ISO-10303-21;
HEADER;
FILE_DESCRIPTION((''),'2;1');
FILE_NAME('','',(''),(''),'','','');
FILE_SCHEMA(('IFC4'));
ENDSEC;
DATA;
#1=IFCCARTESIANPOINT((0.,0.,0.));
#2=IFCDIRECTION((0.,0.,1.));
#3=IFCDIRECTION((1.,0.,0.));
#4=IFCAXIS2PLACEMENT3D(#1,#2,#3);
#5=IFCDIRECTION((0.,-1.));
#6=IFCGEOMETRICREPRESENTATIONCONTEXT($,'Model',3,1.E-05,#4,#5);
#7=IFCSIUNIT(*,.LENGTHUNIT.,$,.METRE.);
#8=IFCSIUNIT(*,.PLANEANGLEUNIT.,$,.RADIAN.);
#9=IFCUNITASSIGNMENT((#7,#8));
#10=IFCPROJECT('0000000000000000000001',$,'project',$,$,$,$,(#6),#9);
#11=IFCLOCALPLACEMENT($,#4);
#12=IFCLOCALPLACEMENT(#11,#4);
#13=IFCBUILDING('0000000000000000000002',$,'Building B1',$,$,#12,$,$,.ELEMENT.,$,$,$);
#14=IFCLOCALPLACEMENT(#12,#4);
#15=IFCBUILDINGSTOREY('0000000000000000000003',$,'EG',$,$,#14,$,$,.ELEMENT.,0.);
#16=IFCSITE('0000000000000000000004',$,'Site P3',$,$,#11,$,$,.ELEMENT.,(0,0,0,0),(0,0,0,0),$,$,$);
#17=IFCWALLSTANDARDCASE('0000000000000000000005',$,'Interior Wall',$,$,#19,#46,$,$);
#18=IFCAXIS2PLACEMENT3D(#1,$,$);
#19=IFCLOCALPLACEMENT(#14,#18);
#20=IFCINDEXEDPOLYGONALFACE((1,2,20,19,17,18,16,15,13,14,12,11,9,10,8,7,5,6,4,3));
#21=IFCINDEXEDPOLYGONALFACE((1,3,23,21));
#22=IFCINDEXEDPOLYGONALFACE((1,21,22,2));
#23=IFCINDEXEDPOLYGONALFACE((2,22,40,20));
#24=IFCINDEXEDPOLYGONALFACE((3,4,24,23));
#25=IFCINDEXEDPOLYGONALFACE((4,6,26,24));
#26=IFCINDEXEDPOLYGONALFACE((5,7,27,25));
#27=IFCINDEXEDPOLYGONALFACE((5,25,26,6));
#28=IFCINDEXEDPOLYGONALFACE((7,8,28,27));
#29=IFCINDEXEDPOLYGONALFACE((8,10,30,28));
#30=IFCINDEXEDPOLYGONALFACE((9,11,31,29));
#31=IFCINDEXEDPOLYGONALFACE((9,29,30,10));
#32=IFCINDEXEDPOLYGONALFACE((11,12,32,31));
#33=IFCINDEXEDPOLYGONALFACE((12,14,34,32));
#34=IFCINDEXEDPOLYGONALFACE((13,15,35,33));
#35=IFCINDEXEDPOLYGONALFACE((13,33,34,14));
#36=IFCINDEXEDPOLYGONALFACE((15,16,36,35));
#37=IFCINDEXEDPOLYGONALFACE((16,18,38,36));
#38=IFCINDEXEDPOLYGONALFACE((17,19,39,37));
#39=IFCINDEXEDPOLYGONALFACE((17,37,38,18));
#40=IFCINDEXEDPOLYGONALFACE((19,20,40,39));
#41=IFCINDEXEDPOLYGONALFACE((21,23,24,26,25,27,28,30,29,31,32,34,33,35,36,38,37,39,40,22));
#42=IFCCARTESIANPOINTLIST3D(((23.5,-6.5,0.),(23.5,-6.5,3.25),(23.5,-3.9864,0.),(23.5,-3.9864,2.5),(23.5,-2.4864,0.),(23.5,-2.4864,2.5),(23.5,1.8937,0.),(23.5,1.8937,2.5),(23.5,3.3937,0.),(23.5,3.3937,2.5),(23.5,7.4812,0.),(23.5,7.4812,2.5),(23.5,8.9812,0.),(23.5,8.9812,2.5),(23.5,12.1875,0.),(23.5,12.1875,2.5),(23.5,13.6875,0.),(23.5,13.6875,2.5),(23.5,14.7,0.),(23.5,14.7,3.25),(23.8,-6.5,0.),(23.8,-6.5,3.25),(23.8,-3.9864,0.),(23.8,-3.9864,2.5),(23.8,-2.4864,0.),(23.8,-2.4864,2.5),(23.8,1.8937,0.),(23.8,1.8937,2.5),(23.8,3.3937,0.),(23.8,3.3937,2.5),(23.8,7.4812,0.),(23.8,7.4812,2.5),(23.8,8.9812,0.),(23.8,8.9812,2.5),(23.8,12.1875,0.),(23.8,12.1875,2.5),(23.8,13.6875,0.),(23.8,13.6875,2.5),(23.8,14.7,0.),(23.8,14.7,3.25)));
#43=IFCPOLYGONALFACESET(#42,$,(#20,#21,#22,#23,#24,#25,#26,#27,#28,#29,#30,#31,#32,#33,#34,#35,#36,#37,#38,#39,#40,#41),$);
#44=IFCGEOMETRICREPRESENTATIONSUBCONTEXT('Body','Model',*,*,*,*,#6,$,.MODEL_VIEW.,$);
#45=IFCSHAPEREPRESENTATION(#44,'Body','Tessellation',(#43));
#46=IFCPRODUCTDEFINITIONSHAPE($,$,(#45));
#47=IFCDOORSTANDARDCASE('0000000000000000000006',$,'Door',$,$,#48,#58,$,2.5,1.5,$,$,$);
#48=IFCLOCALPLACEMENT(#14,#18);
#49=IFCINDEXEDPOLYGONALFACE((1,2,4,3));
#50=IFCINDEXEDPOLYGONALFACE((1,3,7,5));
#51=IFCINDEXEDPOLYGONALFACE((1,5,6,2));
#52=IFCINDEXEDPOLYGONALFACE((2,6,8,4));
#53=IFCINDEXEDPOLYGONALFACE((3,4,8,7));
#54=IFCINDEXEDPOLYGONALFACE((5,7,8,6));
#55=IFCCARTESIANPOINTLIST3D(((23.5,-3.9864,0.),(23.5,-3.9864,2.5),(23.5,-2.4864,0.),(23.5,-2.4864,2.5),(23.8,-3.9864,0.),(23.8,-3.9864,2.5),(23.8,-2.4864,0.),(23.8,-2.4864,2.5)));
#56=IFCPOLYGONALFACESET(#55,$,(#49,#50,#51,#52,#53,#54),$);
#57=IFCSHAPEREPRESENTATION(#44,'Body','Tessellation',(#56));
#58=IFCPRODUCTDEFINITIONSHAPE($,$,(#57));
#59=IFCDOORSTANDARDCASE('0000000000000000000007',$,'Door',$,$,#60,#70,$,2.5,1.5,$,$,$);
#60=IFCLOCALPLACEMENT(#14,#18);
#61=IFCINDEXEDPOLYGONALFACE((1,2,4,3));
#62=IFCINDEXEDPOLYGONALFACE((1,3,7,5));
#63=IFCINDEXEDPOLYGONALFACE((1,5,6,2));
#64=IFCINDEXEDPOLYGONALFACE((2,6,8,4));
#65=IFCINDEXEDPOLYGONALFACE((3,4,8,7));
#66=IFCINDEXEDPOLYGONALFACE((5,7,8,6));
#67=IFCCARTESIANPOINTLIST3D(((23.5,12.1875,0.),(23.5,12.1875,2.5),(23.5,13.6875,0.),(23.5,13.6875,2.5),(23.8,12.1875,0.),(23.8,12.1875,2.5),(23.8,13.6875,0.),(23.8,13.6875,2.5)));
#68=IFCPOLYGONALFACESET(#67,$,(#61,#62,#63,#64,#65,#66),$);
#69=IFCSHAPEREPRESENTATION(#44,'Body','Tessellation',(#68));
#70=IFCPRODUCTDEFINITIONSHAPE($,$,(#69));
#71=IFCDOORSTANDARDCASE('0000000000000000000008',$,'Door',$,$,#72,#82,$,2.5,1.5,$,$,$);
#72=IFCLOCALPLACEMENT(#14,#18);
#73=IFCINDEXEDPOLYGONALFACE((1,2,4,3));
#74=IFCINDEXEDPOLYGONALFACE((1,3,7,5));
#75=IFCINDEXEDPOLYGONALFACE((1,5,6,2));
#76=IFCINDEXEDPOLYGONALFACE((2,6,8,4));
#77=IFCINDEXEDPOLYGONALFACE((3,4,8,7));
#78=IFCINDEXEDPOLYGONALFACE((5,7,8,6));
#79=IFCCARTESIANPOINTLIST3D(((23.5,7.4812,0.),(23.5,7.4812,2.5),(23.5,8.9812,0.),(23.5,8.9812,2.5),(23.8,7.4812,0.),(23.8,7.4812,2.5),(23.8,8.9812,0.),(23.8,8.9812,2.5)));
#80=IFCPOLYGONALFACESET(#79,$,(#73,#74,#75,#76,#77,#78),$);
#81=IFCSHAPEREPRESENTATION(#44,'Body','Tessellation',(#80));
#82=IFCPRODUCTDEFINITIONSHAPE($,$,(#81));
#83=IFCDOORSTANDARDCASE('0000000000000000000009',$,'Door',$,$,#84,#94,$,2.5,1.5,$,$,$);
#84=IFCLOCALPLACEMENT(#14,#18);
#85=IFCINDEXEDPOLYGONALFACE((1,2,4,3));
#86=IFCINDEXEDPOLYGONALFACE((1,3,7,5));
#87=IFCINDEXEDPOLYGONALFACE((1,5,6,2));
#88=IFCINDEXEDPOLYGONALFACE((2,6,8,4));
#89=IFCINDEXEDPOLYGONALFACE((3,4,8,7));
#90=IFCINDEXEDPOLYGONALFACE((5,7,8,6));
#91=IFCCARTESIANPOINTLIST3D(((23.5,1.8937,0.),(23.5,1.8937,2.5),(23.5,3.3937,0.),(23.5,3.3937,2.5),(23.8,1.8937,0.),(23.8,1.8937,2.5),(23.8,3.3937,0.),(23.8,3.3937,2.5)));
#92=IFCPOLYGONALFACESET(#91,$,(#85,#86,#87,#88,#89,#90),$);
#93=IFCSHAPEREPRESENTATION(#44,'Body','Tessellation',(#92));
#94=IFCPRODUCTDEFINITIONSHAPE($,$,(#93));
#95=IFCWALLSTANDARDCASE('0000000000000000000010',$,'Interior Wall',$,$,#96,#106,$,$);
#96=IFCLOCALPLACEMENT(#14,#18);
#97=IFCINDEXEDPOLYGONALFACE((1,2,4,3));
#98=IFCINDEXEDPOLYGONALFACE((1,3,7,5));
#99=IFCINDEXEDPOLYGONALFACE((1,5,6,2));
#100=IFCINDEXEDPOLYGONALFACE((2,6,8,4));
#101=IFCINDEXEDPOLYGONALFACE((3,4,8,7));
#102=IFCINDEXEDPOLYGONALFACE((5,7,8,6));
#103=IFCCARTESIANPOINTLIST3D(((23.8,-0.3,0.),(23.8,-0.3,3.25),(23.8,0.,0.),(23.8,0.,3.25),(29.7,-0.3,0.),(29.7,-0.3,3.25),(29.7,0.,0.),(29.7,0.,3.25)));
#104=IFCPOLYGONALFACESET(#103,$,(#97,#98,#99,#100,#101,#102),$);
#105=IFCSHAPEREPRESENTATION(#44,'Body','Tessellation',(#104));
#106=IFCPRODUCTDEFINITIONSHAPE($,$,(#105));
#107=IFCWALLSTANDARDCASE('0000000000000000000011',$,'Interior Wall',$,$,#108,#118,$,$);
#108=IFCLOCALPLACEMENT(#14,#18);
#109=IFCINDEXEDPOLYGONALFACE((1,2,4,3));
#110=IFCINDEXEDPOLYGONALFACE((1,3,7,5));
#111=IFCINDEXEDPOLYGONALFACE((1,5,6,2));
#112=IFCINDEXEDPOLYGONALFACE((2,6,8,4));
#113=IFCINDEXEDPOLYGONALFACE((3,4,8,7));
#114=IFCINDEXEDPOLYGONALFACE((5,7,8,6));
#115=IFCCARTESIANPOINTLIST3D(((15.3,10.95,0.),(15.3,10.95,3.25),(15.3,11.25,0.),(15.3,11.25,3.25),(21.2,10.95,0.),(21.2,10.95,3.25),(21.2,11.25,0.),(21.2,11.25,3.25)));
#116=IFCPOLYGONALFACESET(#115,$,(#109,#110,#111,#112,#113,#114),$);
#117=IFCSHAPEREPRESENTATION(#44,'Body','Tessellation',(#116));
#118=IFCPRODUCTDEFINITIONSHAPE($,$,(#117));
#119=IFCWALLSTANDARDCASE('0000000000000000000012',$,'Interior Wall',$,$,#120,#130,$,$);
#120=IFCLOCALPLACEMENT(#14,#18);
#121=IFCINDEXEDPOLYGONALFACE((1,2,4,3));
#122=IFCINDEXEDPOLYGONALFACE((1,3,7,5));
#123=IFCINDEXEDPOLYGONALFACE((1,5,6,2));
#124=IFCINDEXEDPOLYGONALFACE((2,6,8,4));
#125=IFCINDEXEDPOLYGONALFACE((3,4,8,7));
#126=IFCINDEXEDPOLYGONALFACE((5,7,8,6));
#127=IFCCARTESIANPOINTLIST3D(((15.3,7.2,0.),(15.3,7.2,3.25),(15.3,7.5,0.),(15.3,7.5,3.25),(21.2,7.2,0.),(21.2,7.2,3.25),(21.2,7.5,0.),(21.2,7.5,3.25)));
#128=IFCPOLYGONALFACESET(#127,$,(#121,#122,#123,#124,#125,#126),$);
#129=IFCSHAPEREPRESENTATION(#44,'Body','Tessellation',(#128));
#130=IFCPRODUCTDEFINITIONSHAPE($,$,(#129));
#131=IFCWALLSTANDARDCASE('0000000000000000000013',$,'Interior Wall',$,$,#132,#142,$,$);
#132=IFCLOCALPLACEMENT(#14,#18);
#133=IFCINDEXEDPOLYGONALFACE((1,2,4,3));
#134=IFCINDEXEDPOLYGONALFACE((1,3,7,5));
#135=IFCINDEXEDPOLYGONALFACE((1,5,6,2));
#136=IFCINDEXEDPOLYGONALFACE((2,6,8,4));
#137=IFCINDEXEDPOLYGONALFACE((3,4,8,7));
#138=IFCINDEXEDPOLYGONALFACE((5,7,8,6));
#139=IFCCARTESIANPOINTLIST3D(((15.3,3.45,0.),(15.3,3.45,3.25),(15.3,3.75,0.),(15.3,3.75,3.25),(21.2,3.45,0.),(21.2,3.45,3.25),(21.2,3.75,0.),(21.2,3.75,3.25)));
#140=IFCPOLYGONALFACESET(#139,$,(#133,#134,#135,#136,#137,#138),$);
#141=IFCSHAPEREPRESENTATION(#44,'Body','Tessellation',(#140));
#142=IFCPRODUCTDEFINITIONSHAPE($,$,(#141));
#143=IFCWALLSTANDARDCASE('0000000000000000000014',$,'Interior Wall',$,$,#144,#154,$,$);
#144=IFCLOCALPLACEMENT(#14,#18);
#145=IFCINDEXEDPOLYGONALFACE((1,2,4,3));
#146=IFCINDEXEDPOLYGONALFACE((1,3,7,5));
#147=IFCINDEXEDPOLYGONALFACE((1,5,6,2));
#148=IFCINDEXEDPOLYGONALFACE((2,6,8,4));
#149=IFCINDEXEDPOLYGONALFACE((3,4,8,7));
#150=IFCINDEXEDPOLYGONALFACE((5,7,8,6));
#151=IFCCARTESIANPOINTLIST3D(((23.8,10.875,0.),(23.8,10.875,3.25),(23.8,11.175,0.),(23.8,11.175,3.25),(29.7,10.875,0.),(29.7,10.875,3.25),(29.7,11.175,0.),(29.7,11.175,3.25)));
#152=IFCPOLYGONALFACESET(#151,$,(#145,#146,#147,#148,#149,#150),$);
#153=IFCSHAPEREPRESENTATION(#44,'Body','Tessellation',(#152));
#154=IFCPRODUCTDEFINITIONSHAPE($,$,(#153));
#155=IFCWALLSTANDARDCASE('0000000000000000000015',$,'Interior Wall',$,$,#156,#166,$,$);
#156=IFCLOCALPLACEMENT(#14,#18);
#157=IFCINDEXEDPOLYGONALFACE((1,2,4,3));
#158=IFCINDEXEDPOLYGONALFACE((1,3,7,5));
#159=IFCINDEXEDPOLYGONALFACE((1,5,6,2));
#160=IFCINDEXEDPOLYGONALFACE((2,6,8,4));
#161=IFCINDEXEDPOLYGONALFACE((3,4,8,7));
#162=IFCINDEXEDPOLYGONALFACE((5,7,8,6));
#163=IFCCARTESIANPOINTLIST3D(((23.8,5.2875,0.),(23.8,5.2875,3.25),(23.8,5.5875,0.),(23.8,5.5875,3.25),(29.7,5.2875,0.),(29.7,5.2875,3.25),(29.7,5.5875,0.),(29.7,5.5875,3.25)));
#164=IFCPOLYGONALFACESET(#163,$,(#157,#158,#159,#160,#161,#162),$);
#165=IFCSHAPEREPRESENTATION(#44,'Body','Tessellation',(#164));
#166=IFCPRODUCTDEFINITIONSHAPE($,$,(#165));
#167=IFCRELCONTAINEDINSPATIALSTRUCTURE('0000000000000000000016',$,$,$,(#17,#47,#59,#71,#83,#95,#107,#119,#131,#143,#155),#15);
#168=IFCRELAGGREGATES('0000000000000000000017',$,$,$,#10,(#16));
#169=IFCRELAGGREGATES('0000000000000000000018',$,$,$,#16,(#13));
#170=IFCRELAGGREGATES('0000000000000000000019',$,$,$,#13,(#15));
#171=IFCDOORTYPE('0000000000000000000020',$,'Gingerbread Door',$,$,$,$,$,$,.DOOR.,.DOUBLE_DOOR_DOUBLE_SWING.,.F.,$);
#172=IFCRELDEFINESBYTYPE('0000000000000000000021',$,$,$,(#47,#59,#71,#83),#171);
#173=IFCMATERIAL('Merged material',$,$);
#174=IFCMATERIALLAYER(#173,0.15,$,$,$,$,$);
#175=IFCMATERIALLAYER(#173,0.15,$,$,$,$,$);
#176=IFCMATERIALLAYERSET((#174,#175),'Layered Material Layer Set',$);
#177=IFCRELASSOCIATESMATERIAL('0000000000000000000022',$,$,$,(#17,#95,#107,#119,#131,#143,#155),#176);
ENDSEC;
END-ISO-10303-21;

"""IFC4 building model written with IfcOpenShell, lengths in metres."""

from ifc_helpers import new_model, si_unit, direction, frame, origin_with_axes, place, context, subcontext, project, spatial, polyline, outline, extrude, source, transform, mapped, material, layer, layer_set, layer_usage, type_object, element, fill, save


model = new_model("IFC4")

# Units and contexts
model_context = context("Model", 3, precision=1e-05, world=origin_with_axes(), true_north=direction((0.0, -1.0)))
body_context = subcontext(model_context, "Body", "Model", "MODEL_VIEW")
ifc_project = project(units=[si_unit("LENGTHUNIT", "METRE"), si_unit("PLANEANGLEUNIT", "RADIAN")], contexts=[model_context])

# Site, building, storey
site_placement = place(None, origin_with_axes())
site = spatial("IfcSite", under=ifc_project, at=site_placement, Name="Site P3", CompositionType="ELEMENT", RefLatitude=(0, 0, 0, 0), RefLongitude=(0, 0, 0, 0))
building_placement = place(site_placement, origin_with_axes())
building = spatial("IfcBuilding", under=site, at=building_placement, Name="Building B1", CompositionType="ELEMENT")
storey_placement = place(building_placement, origin_with_axes())
storey = spatial("IfcBuildingStorey", under=building, at=storey_placement, Name="EG", CompositionType="ELEMENT", Elevation=0.0)

# Shared definitions
ifc_material = material(Name="Merged material")

# Wall, openings, doors
ifc_layer_1 = layer(ifc_material, 0.15)
ifc_layer_2 = layer(ifc_material, 0.15)
ifc_layer_set_1 = layer_set([ifc_layer_1, ifc_layer_2], Name="Layered Material Layer Set")
ifc_layer_usage_1 = layer_usage(ifc_layer_set_1, "AXIS2", "POSITIVE", -0.15)
door_type = type_object("IfcDoorType", Name="Gingerbread Door", OperationType="DOUBLE_DOOR_DOUBLE_SWING", ParameterTakesPrecedence=False, PredefinedType="DOOR")
shared_shape_1 = source(origin_with_axes(), body_context, "Body", "SweptSolid", [
    extrude(outline(polyline([(0.0, 0.0), (0.0, 1.5), (2.5, 1.5), (2.5, 0.0), (0.0, 0.0)])), frame((0.0, -0.15, 0.0), z_axis=(0.0, 1.0, 0.0), x_axis=(0.0, 0.0, 1.0)), (0.0, 0.0, 1.0), 0.3),
])
wall_1_placement = place(storey_placement, frame((23.65, 14.7, 0.0), z_axis=(0.0, 0.0, 1.0), x_axis=(0.0, -1.0, 0.0)))
wall_1 = element("IfcWallStandardCase", 1, at=wall_1_placement, inside=storey, material=ifc_layer_usage_1, Name="Interior Wall", context=body_context, shape_type="SweptSolid", body=[
    extrude(outline(polyline([(0.0, 0.15), (21.2, 0.15), (21.2, -0.15), (0.0, -0.15), (0.0, 0.15)])), origin_with_axes(), (0.0, 0.0, 1.0), 3.25),
])
opening_1_placement = place(wall_1_placement, frame((17.1864, 0.0, 0.0), z_axis=(0.0, 0.0, 1.0), x_axis=(1.0, 0.0, 0.0)))
opening_1 = element("IfcOpeningStandardCase", 2, at=opening_1_placement, cuts=wall_1, context=body_context, shape_type="SweptSolid", body=[
    extrude(outline(polyline([(0.0, 0.0), (0.0, 1.5), (2.5, 1.5), (2.5, 0.0), (0.0, 0.0)])), frame((0.0, -0.15, 0.0), z_axis=(0.0, 1.0, 0.0), x_axis=(0.0, 0.0, 1.0)), (0.0, 0.0, 1.0), 0.3),
])
opening_2_placement = place(wall_1_placement, frame((1.0125, 0.0, 0.0), z_axis=(0.0, 0.0, 1.0), x_axis=(1.0, 0.0, 0.0)))
opening_2 = element("IfcOpeningStandardCase", 3, at=opening_2_placement, cuts=wall_1, context=body_context, shape_type="SweptSolid", body=[
    extrude(outline(polyline([(0.0, 0.0), (0.0, 1.5), (2.5, 1.5), (2.5, 0.0), (0.0, 0.0)])), frame((0.0, -0.15, 0.0), z_axis=(0.0, 1.0, 0.0), x_axis=(0.0, 0.0, 1.0)), (0.0, 0.0, 1.0), 0.3),
])
opening_3_placement = place(wall_1_placement, frame((5.7188, 0.0, 0.0), z_axis=(0.0, 0.0, 1.0), x_axis=(1.0, 0.0, 0.0)))
opening_3 = element("IfcOpeningStandardCase", 4, at=opening_3_placement, cuts=wall_1, context=body_context, shape_type="SweptSolid", body=[
    extrude(outline(polyline([(0.0, 0.0), (0.0, 1.5), (2.5, 1.5), (2.5, 0.0), (0.0, 0.0)])), frame((0.0, -0.15, 0.0), z_axis=(0.0, 1.0, 0.0), x_axis=(0.0, 0.0, 1.0)), (0.0, 0.0, 1.0), 0.3),
])
opening_4_placement = place(wall_1_placement, frame((11.3063, 0.0, 0.0), z_axis=(0.0, 0.0, 1.0), x_axis=(1.0, 0.0, 0.0)))
opening_4 = element("IfcOpeningStandardCase", 5, at=opening_4_placement, cuts=wall_1, context=body_context, shape_type="SweptSolid", body=[
    extrude(outline(polyline([(0.0, 0.0), (0.0, 1.5), (2.5, 1.5), (2.5, 0.0), (0.0, 0.0)])), frame((0.0, -0.15, 0.0), z_axis=(0.0, 1.0, 0.0), x_axis=(0.0, 0.0, 1.0)), (0.0, 0.0, 1.0), 0.3),
])
door_1_placement = place(opening_1_placement, origin_with_axes())
door_1 = element("IfcDoorStandardCase", 6, at=door_1_placement, inside=storey, type_object=door_type, Name="Door", OverallHeight=2.5, OverallWidth=1.5, context=body_context, shape_type="MappedRepresentation", body=[
    mapped(shared_shape_1, transform((0.0, 0.0, 0.0))),
])
fill(opening_1, door_1)
door_2_placement = place(opening_2_placement, origin_with_axes())
door_2 = element("IfcDoorStandardCase", 7, at=door_2_placement, inside=storey, type_object=door_type, Name="Door", OverallHeight=2.5, OverallWidth=1.5, context=body_context, shape_type="MappedRepresentation", body=[
    mapped(shared_shape_1, transform((0.0, 0.0, 0.0))),
])
fill(opening_2, door_2)
door_3_placement = place(opening_3_placement, origin_with_axes())
door_3 = element("IfcDoorStandardCase", 8, at=door_3_placement, inside=storey, type_object=door_type, Name="Door", OverallHeight=2.5, OverallWidth=1.5, context=body_context, shape_type="MappedRepresentation", body=[
    mapped(shared_shape_1, transform((0.0, 0.0, 0.0))),
])
fill(opening_3, door_3)
door_4_placement = place(opening_4_placement, origin_with_axes())
door_4 = element("IfcDoorStandardCase", 9, at=door_4_placement, inside=storey, type_object=door_type, Name="Door", OverallHeight=2.5, OverallWidth=1.5, context=body_context, shape_type="MappedRepresentation", body=[
    mapped(shared_shape_1, transform((0.0, 0.0, 0.0))),
])
fill(opening_4, door_4)

# Walls
for number, where, z_axis, x_axis, name in (
    (10, (23.8, -0.15, 0.0), (0.0, 0.0, 1.0), (1.0, 0.0, 0.0), "Interior Wall"),
    (11, (15.3, 11.1, 0.0), (0.0, 0.0, 1.0), (1.0, 0.0, 0.0), "Interior Wall"),
    (12, (15.3, 7.35, 0.0), (0.0, 0.0, 1.0), (1.0, 0.0, 0.0), "Interior Wall"),
    (13, (15.3, 3.6, 0.0), (0.0, 0.0, 1.0), (1.0, 0.0, 0.0), "Interior Wall"),
    (14, (23.8, 11.025, 0.0), (0.0, 0.0, 1.0), (1.0, 0.0, 0.0), "Interior Wall"),
    (15, (23.8, 5.4375, 0.0), (0.0, 0.0, 1.0), (1.0, 0.0, 0.0), "Interior Wall"),
):
    element("IfcWallStandardCase", number, at=place(storey_placement, frame(where, z_axis=z_axis, x_axis=x_axis)), inside=storey, material=ifc_layer_usage_1, Name=name, context=body_context, shape_type="SweptSolid", body=[
        extrude(outline(polyline([(0.0, 0.15), (5.9, 0.15), (5.9, -0.15), (0.0, -0.15), (0.0, 0.15)])), origin_with_axes(), (0.0, 0.0, 1.0), 3.25),
    ])

save(model, "model.ifc")
